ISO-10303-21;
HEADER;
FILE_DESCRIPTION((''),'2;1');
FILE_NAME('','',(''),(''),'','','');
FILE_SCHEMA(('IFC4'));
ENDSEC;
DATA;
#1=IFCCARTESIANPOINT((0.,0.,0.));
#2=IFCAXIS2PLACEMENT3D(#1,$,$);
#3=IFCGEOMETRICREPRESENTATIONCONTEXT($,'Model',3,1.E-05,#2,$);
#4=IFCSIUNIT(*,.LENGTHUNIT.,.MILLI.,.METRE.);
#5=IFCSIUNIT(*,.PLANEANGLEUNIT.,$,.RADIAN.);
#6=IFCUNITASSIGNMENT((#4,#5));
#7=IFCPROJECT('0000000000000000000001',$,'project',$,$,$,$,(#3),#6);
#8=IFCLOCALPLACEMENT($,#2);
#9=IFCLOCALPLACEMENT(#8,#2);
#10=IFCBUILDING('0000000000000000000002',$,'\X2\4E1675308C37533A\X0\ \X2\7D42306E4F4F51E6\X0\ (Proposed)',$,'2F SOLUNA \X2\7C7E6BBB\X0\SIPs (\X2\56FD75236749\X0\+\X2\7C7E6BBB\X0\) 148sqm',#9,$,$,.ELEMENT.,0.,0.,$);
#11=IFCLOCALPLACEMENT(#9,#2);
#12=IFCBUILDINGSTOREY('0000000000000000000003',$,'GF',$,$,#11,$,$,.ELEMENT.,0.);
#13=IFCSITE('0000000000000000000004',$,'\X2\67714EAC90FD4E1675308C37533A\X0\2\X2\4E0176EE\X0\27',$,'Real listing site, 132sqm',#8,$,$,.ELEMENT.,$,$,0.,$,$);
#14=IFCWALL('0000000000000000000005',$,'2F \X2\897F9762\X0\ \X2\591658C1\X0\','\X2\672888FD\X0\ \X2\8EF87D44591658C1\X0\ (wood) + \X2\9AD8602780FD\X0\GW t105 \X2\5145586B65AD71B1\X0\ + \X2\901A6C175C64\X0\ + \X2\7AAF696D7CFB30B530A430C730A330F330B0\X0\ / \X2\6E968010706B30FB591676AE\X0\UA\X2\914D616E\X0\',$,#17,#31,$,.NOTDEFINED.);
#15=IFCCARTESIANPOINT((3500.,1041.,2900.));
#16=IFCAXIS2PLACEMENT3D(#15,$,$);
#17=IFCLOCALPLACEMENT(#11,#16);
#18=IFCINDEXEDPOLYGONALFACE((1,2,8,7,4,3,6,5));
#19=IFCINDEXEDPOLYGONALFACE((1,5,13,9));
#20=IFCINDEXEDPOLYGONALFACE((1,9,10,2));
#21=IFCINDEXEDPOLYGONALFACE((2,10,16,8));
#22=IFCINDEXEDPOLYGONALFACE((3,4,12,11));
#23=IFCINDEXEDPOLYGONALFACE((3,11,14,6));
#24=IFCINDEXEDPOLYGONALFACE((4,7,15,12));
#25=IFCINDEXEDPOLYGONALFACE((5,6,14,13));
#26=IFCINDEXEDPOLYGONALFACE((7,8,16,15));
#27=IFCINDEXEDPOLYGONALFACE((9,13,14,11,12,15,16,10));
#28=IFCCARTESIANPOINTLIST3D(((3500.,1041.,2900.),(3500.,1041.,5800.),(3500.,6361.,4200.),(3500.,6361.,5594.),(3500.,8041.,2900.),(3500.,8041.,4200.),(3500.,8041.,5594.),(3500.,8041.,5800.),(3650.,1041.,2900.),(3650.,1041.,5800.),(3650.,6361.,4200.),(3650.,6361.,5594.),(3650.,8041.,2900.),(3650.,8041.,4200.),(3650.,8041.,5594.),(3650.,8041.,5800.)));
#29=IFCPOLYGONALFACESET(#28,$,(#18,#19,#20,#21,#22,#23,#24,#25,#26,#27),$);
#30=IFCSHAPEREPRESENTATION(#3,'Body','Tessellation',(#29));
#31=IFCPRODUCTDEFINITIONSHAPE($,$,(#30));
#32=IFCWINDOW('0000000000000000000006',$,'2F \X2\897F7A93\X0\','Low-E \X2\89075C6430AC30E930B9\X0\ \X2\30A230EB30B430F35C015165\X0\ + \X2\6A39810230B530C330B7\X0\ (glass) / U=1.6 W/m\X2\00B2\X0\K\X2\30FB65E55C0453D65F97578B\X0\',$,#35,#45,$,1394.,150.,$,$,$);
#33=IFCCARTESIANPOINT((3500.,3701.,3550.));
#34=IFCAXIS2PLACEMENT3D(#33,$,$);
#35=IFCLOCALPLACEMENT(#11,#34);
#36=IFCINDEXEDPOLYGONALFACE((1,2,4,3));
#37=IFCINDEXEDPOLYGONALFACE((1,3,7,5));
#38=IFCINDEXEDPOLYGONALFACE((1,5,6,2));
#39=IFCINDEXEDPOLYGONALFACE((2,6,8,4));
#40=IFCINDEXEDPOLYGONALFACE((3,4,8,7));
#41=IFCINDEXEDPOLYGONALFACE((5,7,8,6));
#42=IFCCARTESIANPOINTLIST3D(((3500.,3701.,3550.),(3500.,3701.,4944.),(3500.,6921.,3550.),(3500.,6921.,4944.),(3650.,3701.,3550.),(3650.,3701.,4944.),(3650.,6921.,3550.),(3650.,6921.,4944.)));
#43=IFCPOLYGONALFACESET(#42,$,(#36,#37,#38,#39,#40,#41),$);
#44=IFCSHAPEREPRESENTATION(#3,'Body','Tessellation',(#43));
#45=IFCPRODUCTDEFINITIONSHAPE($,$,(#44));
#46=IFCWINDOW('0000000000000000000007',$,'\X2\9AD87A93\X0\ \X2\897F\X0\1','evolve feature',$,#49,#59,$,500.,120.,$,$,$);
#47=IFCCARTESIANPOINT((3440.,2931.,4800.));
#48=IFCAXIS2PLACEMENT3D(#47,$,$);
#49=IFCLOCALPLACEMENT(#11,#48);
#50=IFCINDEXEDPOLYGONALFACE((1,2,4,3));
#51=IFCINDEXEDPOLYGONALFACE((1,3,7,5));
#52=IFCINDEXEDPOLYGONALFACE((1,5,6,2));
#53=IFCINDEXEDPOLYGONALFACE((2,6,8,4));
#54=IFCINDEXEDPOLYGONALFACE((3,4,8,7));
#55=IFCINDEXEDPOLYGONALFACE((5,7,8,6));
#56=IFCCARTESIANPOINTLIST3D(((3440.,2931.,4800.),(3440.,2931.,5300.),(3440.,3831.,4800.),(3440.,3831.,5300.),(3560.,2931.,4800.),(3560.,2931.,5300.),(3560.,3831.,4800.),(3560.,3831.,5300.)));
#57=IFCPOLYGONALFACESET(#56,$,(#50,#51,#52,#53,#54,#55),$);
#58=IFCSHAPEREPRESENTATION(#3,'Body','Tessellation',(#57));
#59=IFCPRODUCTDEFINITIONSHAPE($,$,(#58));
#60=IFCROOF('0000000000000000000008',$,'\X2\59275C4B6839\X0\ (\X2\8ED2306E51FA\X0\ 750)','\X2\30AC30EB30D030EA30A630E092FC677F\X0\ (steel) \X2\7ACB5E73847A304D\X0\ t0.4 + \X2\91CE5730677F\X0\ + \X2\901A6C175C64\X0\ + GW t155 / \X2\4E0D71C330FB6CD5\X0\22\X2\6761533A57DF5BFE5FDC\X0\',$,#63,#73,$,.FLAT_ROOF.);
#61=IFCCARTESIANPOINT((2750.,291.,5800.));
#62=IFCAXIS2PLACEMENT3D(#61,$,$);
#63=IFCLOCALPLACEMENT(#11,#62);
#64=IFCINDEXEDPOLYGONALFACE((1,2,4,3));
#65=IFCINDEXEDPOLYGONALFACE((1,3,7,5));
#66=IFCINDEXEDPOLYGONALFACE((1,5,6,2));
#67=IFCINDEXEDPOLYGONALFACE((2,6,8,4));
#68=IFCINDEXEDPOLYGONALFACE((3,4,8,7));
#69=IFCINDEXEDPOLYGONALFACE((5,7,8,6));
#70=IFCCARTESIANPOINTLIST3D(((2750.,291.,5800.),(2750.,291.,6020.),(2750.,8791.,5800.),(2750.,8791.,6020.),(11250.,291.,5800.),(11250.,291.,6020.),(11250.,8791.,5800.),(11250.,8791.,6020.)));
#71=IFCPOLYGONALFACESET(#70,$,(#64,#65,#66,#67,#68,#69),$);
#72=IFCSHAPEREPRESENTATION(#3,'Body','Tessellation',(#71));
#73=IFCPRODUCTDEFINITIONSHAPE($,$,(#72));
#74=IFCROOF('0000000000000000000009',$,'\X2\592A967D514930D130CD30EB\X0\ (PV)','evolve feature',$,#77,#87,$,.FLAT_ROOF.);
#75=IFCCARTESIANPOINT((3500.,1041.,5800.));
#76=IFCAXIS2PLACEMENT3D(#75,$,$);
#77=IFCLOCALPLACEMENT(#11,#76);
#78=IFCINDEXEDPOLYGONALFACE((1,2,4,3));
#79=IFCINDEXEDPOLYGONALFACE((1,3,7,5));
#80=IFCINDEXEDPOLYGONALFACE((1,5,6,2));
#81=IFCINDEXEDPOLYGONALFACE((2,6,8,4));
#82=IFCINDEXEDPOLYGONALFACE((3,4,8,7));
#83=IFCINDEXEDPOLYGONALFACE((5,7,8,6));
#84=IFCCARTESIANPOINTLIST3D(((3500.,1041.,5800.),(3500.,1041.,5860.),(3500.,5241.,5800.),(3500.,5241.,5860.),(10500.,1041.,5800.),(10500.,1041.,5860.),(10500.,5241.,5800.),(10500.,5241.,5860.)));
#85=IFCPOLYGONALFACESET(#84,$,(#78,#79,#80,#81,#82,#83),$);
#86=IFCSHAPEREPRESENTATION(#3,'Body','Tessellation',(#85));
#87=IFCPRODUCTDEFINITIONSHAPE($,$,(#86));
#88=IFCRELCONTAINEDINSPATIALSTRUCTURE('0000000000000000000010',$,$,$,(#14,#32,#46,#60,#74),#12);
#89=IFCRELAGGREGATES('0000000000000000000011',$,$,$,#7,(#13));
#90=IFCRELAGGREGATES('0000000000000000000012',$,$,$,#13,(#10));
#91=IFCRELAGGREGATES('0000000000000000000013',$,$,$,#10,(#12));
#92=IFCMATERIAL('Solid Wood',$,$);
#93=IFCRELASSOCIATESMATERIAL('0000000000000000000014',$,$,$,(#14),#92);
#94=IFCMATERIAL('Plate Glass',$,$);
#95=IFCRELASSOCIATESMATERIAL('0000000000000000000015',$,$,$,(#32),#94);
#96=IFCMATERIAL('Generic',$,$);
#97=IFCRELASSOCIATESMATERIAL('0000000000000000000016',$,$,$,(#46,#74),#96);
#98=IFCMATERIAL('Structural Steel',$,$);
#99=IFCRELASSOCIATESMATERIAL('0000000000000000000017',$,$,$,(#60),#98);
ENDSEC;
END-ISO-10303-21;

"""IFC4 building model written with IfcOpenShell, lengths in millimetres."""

from ifc_helpers import new_model, si_unit, frame, frame_2d, origin, place, context, project, spatial, rectangle, extrude, material, element, fill, save


model = new_model("IFC4")

# Units and contexts
model_context = context("Model", 3, precision=1e-05, world=origin())
ifc_project = project(units=[si_unit("LENGTHUNIT", "METRE", prefix="MILLI"), si_unit("PLANEANGLEUNIT", "RADIAN")], contexts=[model_context])

# Site, building, storey
site_placement = place(None, origin())
site = spatial("IfcSite", under=ifc_project, at=site_placement, Name="東京都世田谷区2丁目27", ObjectType="Real listing site, 132sqm", CompositionType="ELEMENT", RefElevation=0.0)
building_placement = place(site_placement, origin())
building = spatial("IfcBuilding", under=site, at=building_placement, Name="世田谷区 終の住処 (Proposed)", ObjectType="2F SOLUNA 籾殻SIPs (国産杉+籾殻) 148sqm", CompositionType="ELEMENT", ElevationOfRefHeight=0.0, ElevationOfTerrain=0.0)
storey_placement = place(building_placement, origin())
storey = spatial("IfcBuildingStorey", under=building, at=storey_placement, Name="GF", CompositionType="ELEMENT", Elevation=0.0)

# Shared definitions
ifc_material_1 = material(Name="Solid Wood")
ifc_material_2 = material(Name="Generic")

# Shared definitions
ifc_material_3 = material(Name="Plate Glass")

# Wall, openings, windows
wall_1_placement = place(storey_placement, frame((3500.0, 1041.0, 2900.0)))
wall_1 = element("IfcWall", 1, at=wall_1_placement, inside=storey, material=ifc_material_1, Name="2F 西面 外壁", Description="木製 軸組外壁 (wood) + 高性能GW t105 充填断熱 + 通気層 + 窯業系サイディング / 準耐火・外皮UA配慮", PredefinedType="NOTDEFINED", context=model_context, shape_type="SweptSolid", body=[
    extrude(rectangle(XDim=150.0, YDim=7000.0, at=frame_2d((75.0, 3500.0))), frame((3500.0, 1041.0, 2900.0)), (0.0, 0.0, 1.0), 2900.0),
])
opening_1_placement = place(storey_placement, frame((3500.0, 3701.0, 3550.0)))
opening_1 = element("IfcOpeningElement", 2, at=opening_1_placement, cuts=wall_1, PredefinedType="NOTDEFINED", context=model_context, shape_type="SweptSolid", body=[
    extrude(rectangle(XDim=150.0, YDim=3220.0, at=frame_2d((75.0, 1610.0))), frame((3500.0, 3701.0, 3550.0)), (0.0, 0.0, 1.0), 1394.0),
])
opening_2_placement = place(storey_placement, frame((3440.0, 2931.0, 4800.0)))
opening_2 = element("IfcOpeningElement", 3, at=opening_2_placement, cuts=wall_1, PredefinedType="NOTDEFINED", context=model_context, shape_type="SweptSolid", body=[
    extrude(rectangle(XDim=120.0, YDim=900.0, at=frame_2d((60.0, 450.0))), frame((3440.0, 2931.0, 4800.0)), (0.0, 0.0, 1.0), 500.0),
])
window_1_placement = place(storey_placement, frame((3500.0, 3701.0, 3550.0)))
window_1 = element("IfcWindow", 4, at=window_1_placement, inside=storey, material=ifc_material_3, Name="2F 西窓", Description="Low-E 複層ガラス アルゴン封入 + 樹脂サッシ (glass) / U=1.6 W/m²K・日射取得型", OverallHeight=1394.0, OverallWidth=150.0, context=model_context, shape_type="SweptSolid", body=[
    extrude(rectangle(XDim=150.0, YDim=3220.0, at=frame_2d((75.0, 1610.0))), frame((3500.0, 3701.0, 3550.0)), (0.0, 0.0, 1.0), 1394.0),
])
fill(opening_1, window_1)
window_2_placement = place(storey_placement, frame((3440.0, 2931.0, 4800.0)))
window_2 = element("IfcWindow", 5, at=window_2_placement, inside=storey, material=ifc_material_2, Name="高窓 西1", Description="evolve feature", OverallHeight=500.0, OverallWidth=120.0, context=model_context, shape_type="SweptSolid", body=[
    extrude(rectangle(XDim=120.0, YDim=900.0, at=frame_2d((60.0, 450.0))), frame((3440.0, 2931.0, 4800.0)), (0.0, 0.0, 1.0), 500.0),
])
fill(opening_2, window_2)

# Roofs
ifc_material_4 = material(Name="Structural Steel")
roof_1_placement = place(storey_placement, frame((2750.0, 291.0, 5800.0)))
element("IfcRoof", 6, at=roof_1_placement, inside=storey, material=ifc_material_4, Name="大屋根 (軒の出 750)", Description="ガルバリウム鋼板 (steel) 立平葺き t0.4 + 野地板 + 通気層 + GW t155 / 不燃・法22条区域対応", PredefinedType="FLAT_ROOF", context=model_context, shape_type="SweptSolid", body=[
    extrude(rectangle(XDim=8500.0, YDim=8500.0, at=frame_2d((4250.0, 4250.0))), frame((2750.0, 291.0, 5800.0)), (0.0, 0.0, 1.0), 220.0),
])
roof_2_placement = place(storey_placement, frame((3500.0, 1041.0, 5800.0)))
element("IfcRoof", 7, at=roof_2_placement, inside=storey, material=ifc_material_2, Name="太陽光パネル (PV)", Description="evolve feature", PredefinedType="FLAT_ROOF", context=model_context, shape_type="SweptSolid", body=[
    extrude(rectangle(XDim=7000.0, YDim=4200.0, at=frame_2d((3500.0, 2100.0))), frame((3500.0, 1041.0, 5800.0)), (0.0, 0.0, 1.0), 60.0),
])

save(model, "model.ifc")
